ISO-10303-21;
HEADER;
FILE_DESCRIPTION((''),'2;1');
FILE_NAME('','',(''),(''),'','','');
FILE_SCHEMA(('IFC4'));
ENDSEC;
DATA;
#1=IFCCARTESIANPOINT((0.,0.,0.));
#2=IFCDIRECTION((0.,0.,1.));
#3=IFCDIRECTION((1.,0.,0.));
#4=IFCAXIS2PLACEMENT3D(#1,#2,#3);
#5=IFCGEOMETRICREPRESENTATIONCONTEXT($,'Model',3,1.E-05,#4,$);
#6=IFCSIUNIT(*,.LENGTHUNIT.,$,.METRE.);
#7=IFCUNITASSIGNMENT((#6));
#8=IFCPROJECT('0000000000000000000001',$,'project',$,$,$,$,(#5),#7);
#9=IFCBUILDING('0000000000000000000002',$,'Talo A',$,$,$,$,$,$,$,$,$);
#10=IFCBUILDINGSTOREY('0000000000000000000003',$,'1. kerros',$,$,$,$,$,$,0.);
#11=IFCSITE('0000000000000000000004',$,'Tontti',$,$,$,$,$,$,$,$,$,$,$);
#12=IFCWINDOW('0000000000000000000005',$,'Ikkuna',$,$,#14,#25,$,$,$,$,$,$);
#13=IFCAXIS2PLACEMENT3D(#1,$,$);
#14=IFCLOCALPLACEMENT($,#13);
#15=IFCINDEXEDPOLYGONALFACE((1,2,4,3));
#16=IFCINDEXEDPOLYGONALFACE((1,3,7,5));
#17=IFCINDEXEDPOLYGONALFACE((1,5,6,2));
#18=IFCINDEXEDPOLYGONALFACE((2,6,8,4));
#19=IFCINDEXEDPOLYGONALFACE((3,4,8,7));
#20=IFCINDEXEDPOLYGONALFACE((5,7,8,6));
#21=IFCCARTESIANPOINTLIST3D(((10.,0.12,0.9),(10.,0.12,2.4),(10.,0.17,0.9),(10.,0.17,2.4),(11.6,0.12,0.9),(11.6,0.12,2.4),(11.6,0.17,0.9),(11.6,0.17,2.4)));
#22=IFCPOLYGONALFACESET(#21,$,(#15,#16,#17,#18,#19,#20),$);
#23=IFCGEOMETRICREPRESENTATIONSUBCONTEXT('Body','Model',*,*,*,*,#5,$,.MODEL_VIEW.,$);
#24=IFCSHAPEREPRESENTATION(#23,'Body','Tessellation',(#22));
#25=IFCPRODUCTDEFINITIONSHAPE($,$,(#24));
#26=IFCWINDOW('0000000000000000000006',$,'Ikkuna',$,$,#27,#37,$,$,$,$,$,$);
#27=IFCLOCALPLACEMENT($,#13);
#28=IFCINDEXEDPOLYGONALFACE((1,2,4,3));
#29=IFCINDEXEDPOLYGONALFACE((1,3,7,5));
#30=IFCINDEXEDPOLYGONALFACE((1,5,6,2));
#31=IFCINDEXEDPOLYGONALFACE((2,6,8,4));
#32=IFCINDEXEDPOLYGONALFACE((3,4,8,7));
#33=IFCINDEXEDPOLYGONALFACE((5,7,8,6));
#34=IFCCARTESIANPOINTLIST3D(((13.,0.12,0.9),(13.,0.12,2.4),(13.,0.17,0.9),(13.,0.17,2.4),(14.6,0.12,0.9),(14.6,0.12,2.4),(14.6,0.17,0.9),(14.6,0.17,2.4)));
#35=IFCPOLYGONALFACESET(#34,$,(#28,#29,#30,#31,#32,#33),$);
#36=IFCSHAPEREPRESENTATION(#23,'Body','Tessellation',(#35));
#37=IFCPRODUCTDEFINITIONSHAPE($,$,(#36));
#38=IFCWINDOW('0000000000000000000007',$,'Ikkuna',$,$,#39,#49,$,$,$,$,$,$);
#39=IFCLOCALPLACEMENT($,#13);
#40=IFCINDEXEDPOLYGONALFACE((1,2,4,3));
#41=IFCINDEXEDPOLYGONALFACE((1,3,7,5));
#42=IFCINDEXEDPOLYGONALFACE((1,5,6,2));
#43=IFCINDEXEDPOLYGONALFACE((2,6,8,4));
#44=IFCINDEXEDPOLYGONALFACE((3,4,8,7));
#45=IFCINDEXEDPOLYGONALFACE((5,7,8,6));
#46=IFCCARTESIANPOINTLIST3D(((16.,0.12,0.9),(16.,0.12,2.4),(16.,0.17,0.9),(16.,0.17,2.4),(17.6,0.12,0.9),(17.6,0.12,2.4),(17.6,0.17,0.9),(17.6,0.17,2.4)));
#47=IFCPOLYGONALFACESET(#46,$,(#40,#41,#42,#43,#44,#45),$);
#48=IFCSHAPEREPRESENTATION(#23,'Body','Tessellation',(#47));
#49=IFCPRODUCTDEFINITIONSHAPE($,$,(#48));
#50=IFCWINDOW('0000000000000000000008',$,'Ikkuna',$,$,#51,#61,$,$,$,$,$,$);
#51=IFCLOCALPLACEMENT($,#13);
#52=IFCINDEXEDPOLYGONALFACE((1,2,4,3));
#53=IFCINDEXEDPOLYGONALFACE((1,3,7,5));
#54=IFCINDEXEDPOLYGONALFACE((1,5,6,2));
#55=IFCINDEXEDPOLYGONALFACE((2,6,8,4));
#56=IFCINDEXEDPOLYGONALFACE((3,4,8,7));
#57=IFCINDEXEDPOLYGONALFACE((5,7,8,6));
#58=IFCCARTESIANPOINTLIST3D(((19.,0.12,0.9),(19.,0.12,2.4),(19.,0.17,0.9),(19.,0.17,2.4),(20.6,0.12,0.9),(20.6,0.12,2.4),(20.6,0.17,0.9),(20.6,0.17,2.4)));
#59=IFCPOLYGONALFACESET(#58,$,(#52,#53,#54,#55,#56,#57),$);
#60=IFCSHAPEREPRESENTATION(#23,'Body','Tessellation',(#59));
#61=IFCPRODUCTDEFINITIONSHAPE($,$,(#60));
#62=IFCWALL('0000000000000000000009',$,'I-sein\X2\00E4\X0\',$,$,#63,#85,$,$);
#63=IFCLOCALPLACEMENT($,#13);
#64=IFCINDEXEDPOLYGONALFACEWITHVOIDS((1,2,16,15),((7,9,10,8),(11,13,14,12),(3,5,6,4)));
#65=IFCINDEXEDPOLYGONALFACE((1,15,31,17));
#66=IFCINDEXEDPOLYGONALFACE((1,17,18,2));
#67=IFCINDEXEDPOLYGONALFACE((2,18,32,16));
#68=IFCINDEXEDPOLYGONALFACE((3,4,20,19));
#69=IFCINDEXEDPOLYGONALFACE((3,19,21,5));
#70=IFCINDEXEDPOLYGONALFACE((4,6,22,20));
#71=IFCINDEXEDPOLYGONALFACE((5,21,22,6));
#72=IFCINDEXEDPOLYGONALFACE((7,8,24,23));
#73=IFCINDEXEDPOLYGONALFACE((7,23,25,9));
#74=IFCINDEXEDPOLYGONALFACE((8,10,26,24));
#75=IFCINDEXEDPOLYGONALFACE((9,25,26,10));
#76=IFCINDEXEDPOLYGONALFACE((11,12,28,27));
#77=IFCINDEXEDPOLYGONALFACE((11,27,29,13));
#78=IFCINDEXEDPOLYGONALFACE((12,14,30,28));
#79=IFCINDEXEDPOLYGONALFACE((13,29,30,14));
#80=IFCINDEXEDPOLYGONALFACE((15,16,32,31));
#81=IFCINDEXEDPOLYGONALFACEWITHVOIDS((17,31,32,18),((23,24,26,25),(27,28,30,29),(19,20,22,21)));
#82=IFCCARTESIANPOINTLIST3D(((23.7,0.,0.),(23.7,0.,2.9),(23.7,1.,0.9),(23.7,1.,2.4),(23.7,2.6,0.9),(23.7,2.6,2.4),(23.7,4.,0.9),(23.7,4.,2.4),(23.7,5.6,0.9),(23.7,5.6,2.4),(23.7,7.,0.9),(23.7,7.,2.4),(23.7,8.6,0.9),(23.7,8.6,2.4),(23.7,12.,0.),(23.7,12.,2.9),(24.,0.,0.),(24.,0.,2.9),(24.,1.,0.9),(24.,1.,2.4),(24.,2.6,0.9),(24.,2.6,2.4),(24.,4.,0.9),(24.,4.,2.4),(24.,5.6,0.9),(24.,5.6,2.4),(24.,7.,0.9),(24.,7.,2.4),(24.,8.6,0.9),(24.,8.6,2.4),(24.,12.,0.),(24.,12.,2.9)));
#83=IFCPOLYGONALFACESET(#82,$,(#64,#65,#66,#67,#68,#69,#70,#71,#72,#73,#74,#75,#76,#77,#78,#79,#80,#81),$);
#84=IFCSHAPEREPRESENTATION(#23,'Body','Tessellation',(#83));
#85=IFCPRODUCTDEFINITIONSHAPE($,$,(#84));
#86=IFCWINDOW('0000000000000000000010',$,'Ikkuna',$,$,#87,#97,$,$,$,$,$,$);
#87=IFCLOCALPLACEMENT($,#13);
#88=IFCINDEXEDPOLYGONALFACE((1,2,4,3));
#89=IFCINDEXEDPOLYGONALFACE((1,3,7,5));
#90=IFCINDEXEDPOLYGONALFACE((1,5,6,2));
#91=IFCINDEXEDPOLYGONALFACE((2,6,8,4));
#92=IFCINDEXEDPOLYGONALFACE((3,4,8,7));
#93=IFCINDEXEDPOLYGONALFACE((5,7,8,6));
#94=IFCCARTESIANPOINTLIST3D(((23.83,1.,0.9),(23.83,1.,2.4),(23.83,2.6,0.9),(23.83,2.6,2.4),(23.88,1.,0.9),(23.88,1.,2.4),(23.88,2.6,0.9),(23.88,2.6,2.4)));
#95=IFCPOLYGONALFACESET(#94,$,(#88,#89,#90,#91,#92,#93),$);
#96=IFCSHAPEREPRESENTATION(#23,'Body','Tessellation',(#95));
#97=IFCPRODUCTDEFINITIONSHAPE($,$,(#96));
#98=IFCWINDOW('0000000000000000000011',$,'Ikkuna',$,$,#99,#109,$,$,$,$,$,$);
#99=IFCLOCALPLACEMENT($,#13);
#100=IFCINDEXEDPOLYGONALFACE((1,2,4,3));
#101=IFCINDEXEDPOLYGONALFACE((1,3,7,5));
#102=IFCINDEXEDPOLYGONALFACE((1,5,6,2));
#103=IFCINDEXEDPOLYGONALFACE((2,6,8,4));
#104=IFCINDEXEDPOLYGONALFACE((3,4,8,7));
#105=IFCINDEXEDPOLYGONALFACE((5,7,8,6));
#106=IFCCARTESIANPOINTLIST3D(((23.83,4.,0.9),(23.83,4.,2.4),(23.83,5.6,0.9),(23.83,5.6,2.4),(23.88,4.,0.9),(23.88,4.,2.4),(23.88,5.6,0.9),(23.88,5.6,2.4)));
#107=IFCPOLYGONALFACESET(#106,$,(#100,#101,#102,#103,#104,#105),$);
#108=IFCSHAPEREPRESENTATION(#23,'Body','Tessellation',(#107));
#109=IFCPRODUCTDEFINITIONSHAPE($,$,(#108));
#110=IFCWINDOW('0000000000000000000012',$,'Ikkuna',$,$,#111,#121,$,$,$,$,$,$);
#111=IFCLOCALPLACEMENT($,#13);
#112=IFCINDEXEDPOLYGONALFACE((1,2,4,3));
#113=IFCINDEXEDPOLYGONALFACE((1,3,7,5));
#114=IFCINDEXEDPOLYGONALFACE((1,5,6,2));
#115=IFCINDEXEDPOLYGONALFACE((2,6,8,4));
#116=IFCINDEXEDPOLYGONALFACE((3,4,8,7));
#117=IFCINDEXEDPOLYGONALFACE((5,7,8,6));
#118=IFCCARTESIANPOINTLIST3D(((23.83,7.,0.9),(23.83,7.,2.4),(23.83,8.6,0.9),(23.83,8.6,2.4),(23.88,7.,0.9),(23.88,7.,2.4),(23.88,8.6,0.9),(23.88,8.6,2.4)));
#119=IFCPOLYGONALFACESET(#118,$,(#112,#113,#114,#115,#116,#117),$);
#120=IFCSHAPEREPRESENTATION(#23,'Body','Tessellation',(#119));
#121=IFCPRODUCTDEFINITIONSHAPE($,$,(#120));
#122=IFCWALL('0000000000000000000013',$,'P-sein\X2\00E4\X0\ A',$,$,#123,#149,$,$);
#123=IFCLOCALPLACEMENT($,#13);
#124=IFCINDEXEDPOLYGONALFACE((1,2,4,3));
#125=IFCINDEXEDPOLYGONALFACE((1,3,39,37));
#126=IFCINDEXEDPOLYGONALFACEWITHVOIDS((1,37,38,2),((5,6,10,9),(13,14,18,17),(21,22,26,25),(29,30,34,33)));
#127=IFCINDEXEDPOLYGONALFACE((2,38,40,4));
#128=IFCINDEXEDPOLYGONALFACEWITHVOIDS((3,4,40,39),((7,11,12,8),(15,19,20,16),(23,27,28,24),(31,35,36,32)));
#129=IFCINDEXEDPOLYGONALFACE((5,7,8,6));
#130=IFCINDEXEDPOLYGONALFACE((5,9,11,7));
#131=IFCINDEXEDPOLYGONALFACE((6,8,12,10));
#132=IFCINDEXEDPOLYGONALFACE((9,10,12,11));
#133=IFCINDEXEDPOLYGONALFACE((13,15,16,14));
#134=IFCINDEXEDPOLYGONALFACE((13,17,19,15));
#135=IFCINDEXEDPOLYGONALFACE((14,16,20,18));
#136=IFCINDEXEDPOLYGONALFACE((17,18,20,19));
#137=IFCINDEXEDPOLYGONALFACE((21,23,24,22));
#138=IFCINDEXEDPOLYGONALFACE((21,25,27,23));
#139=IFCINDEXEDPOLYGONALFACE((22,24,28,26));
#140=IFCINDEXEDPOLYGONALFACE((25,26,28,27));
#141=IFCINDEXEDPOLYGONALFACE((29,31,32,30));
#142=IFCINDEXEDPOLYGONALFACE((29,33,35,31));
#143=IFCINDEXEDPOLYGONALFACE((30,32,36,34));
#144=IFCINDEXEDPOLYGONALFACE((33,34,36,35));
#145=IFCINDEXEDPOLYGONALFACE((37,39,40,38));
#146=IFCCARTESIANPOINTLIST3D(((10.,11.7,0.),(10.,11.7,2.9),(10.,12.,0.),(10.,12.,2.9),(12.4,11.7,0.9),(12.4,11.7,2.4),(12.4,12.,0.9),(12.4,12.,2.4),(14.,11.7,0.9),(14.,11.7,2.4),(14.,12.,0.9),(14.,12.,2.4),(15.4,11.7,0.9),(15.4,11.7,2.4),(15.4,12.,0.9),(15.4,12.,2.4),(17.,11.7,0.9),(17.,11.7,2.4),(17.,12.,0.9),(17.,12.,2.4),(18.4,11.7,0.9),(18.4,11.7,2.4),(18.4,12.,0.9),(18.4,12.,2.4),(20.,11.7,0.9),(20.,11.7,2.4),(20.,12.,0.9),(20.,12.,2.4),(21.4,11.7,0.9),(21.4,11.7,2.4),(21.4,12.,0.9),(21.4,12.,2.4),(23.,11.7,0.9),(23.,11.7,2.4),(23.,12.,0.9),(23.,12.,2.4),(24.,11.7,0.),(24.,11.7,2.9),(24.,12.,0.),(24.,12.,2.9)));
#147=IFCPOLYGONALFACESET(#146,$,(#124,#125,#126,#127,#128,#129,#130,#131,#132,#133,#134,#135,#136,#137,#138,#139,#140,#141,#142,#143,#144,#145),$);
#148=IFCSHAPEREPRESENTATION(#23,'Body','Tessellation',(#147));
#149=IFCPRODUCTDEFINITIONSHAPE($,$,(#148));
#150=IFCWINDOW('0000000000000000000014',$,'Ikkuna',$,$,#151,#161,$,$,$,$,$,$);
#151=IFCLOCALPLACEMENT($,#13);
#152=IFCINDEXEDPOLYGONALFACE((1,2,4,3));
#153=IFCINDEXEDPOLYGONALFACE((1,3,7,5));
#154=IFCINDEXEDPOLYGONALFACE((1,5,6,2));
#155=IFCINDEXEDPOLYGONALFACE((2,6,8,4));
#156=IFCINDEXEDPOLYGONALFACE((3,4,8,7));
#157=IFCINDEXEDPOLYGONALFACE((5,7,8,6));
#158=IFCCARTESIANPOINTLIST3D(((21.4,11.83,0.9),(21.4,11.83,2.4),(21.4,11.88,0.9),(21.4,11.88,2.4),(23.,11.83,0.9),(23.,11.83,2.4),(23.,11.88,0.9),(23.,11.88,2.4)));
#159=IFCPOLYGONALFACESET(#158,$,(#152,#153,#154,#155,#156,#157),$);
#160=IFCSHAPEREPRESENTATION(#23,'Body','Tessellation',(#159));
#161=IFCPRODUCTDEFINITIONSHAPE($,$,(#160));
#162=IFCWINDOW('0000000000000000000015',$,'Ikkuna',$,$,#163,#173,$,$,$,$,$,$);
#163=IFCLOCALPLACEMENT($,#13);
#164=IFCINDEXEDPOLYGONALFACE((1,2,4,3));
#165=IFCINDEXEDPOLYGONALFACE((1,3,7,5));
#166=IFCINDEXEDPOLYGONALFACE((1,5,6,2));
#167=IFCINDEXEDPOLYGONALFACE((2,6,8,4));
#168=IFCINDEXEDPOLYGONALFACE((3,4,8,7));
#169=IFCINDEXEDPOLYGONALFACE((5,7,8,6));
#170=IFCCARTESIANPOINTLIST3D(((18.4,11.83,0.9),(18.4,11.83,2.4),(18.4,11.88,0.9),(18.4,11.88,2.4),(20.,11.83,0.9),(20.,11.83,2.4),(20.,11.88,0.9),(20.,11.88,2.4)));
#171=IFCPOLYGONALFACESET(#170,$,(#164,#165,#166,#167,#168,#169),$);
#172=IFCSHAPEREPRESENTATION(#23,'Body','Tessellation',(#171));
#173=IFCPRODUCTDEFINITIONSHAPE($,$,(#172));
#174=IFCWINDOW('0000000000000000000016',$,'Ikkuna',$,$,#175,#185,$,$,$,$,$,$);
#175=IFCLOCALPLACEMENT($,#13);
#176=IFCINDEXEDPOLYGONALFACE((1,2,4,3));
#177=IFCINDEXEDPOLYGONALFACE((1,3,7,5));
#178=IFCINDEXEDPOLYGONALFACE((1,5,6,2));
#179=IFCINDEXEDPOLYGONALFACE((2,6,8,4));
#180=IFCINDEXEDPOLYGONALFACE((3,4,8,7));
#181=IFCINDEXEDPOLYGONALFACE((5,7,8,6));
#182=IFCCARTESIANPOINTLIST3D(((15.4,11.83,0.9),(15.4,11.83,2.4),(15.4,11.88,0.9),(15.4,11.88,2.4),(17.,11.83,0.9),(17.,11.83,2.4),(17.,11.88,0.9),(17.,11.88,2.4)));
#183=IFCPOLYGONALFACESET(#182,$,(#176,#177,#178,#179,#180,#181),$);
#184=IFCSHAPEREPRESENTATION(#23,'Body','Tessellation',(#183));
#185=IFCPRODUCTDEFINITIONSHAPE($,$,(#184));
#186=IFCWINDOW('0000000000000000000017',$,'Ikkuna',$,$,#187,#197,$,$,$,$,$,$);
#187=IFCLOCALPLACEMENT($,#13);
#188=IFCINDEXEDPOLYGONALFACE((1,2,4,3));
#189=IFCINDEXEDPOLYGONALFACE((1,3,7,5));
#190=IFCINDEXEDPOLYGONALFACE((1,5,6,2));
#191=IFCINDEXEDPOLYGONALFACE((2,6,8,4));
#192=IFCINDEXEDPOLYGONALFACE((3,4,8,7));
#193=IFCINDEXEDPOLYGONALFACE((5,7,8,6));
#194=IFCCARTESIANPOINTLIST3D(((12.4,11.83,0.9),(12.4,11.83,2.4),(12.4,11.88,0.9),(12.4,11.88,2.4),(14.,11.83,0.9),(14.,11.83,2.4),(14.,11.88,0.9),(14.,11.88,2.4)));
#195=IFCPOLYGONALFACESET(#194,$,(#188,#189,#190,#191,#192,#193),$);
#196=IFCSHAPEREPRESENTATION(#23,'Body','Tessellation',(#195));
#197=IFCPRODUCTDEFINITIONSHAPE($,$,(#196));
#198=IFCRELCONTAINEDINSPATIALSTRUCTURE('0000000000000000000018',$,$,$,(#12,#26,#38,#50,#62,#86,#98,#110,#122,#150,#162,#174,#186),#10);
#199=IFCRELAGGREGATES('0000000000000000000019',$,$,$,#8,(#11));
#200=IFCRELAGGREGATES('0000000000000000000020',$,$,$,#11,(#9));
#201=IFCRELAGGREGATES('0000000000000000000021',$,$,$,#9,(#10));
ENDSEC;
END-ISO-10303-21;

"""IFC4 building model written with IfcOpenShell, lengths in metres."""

from ifc_helpers import new_model, si_unit, frame, origin_with_axes, place, context, subcontext, project, spatial, indexed_curve, outline, extrude, element, save


model = new_model("IFC4")

# Units and contexts
model_context = context("Model", 3, precision=1e-05, world=origin_with_axes())
body_context = subcontext(model_context, "Body", "Model", "MODEL_VIEW")
ifc_project = project(units=[si_unit("LENGTHUNIT", "METRE")], contexts=[model_context])

# Site, building, storey
site = spatial("IfcSite", under=ifc_project, Name="Tontti")
building = spatial("IfcBuilding", under=site, Name="Talo A")
storey = spatial("IfcBuildingStorey", under=building, Name="1. kerros", Elevation=0.0)

# Windows
for number, where, z_axis, x_axis, name in (
    (1, (10.0, 0.12, 0.9), (0.0, 0.0, 1.0), (1.0, 0.0, 0.0), "Ikkuna"),
    (2, (13.0, 0.12, 0.9), (0.0, 0.0, 1.0), (1.0, 0.0, 0.0), "Ikkuna"),
    (3, (16.0, 0.12, 0.9), (0.0, 0.0, 1.0), (1.0, 0.0, 0.0), "Ikkuna"),
    (4, (19.0, 0.12, 0.9), (0.0, 0.0, 1.0), (1.0, 0.0, 0.0), "Ikkuna"),
):
    element("IfcWindow", number, at=place(None, frame(where, z_axis=z_axis, x_axis=x_axis)), inside=storey, Name=name, context=body_context, shape_type="SweptSolid", body=[
        extrude(outline(indexed_curve([(0.0, 0.0), (0.0, 0.05), (1.6, 0.05), (1.6, 0.0), (0.0, 0.0)], self_intersect=False)), origin_with_axes(), (0.0, 0.0, 1.0), 1.5),
    ])

# Wall, openings
wall_1_placement = place(None, frame((24.0, 0.0, 0.0), z_axis=(0.0, 0.0, 1.0), x_axis=(0.0, 1.0, 0.0)))
wall_1 = element("IfcWall", 5, at=wall_1_placement, inside=storey, Name="I-seinä", context=body_context, shape_type="SweptSolid", body=[
    extrude(outline(indexed_curve([(0.0, 0.0), (0.0, 0.3), (12.0, 0.3), (12.0, 0.0), (0.0, 0.0)], self_intersect=False)), origin_with_axes(), (0.0, 0.0, 1.0), 2.9),
])
opening_1_placement = place(wall_1_placement, frame((1.0, -0.1, 0.9), z_axis=(0.0, 0.0, 1.0), x_axis=(1.0, 0.0, 0.0)))
element("IfcOpeningElement", 6, at=opening_1_placement, cuts=wall_1, context=body_context, shape_type="SweptSolid", body=[
    extrude(outline(indexed_curve([(0.0, 0.0), (0.0, 0.5), (1.6, 0.5), (1.6, 0.0), (0.0, 0.0)], self_intersect=False)), origin_with_axes(), (0.0, 0.0, 1.0), 1.5),
])
opening_2_placement = place(wall_1_placement, frame((4.0, -0.1, 0.9), z_axis=(0.0, 0.0, 1.0), x_axis=(1.0, 0.0, 0.0)))
element("IfcOpeningElement", 7, at=opening_2_placement, cuts=wall_1, context=body_context, shape_type="SweptSolid", body=[
    extrude(outline(indexed_curve([(0.0, 0.0), (0.0, 0.5), (1.6, 0.5), (1.6, 0.0), (0.0, 0.0)], self_intersect=False)), origin_with_axes(), (0.0, 0.0, 1.0), 1.5),
])
opening_3_placement = place(wall_1_placement, frame((7.0, -0.1, 0.9), z_axis=(0.0, 0.0, 1.0), x_axis=(1.0, 0.0, 0.0)))
element("IfcOpeningElement", 8, at=opening_3_placement, cuts=wall_1, context=body_context, shape_type="SweptSolid", body=[
    extrude(outline(indexed_curve([(0.0, 0.0), (0.0, 0.5), (1.6, 0.5), (1.6, 0.0), (0.0, 0.0)], self_intersect=False)), origin_with_axes(), (0.0, 0.0, 1.0), 1.5),
])

# Windows
for number, where, z_axis, x_axis, name in (
    (9, (23.88, 1.0, 0.9), (0.0, 0.0, 1.0), (0.0, 1.0, 0.0), "Ikkuna"),
    (10, (23.88, 4.0, 0.9), (0.0, 0.0, 1.0), (0.0, 1.0, 0.0), "Ikkuna"),
    (11, (23.88, 7.0, 0.9), (0.0, 0.0, 1.0), (0.0, 1.0, 0.0), "Ikkuna"),
):
    element("IfcWindow", number, at=place(None, frame(where, z_axis=z_axis, x_axis=x_axis)), inside=storey, Name=name, context=body_context, shape_type="SweptSolid", body=[
        extrude(outline(indexed_curve([(0.0, 0.0), (0.0, 0.05), (1.6, 0.05), (1.6, 0.0), (0.0, 0.0)], self_intersect=False)), origin_with_axes(), (0.0, 0.0, 1.0), 1.5),
    ])

# Wall, openings
wall_2_placement = place(None, frame((24.0, 12.0, 0.0), z_axis=(0.0, 0.0, 1.0), x_axis=(-1.0, 0.0, 0.0)))
wall_2 = element("IfcWall", 12, at=wall_2_placement, inside=storey, Name="P-seinä A", context=body_context, shape_type="SweptSolid", body=[
    extrude(outline(indexed_curve([(0.0, 0.0), (0.0, 0.3), (14.0, 0.3), (14.0, 0.0), (0.0, 0.0)], self_intersect=False)), origin_with_axes(), (0.0, 0.0, 1.0), 2.9),
])
opening_4_placement = place(wall_2_placement, frame((1.0, -0.1, 0.9), z_axis=(0.0, 0.0, 1.0), x_axis=(1.0, 0.0, 0.0)))
element("IfcOpeningElement", 13, at=opening_4_placement, cuts=wall_2, context=body_context, shape_type="SweptSolid", body=[
    extrude(outline(indexed_curve([(0.0, 0.0), (0.0, 0.5), (1.6, 0.5), (1.6, 0.0), (0.0, 0.0)], self_intersect=False)), origin_with_axes(), (0.0, 0.0, 1.0), 1.5),
])
opening_5_placement = place(wall_2_placement, frame((4.0, -0.1, 0.9), z_axis=(0.0, 0.0, 1.0), x_axis=(1.0, 0.0, 0.0)))
element("IfcOpeningElement", 14, at=opening_5_placement, cuts=wall_2, context=body_context, shape_type="SweptSolid", body=[
    extrude(outline(indexed_curve([(0.0, 0.0), (0.0, 0.5), (1.6, 0.5), (1.6, 0.0), (0.0, 0.0)], self_intersect=False)), origin_with_axes(), (0.0, 0.0, 1.0), 1.5),
])
opening_6_placement = place(wall_2_placement, frame((7.0, -0.1, 0.9), z_axis=(0.0, 0.0, 1.0), x_axis=(1.0, 0.0, 0.0)))
element("IfcOpeningElement", 15, at=opening_6_placement, cuts=wall_2, context=body_context, shape_type="SweptSolid", body=[
    extrude(outline(indexed_curve([(0.0, 0.0), (0.0, 0.5), (1.6, 0.5), (1.6, 0.0), (0.0, 0.0)], self_intersect=False)), origin_with_axes(), (0.0, 0.0, 1.0), 1.5),
])
opening_7_placement = place(wall_2_placement, frame((10.0, -0.1, 0.9), z_axis=(0.0, 0.0, 1.0), x_axis=(1.0, 0.0, 0.0)))
element("IfcOpeningElement", 16, at=opening_7_placement, cuts=wall_2, context=body_context, shape_type="SweptSolid", body=[
    extrude(outline(indexed_curve([(0.0, 0.0), (0.0, 0.5), (1.6, 0.5), (1.6, 0.0), (0.0, 0.0)], self_intersect=False)), origin_with_axes(), (0.0, 0.0, 1.0), 1.5),
])

# Windows
for number, where, z_axis, x_axis, name in (
    (17, (23.0, 11.88, 0.9), (0.0, 0.0, 1.0), (-1.0, 0.0, 0.0), "Ikkuna"),
    (18, (20.0, 11.88, 0.9), (0.0, 0.0, 1.0), (-1.0, 0.0, 0.0), "Ikkuna"),
    (19, (17.0, 11.88, 0.9), (0.0, 0.0, 1.0), (-1.0, 0.0, 0.0), "Ikkuna"),
    (20, (14.0, 11.88, 0.9), (0.0, 0.0, 1.0), (-1.0, 0.0, 0.0), "Ikkuna"),
):
    element("IfcWindow", number, at=place(None, frame(where, z_axis=z_axis, x_axis=x_axis)), inside=storey, Name=name, context=body_context, shape_type="SweptSolid", body=[
        extrude(outline(indexed_curve([(0.0, 0.0), (0.0, 0.05), (1.6, 0.05), (1.6, 0.0), (0.0, 0.0)], self_intersect=False)), origin_with_axes(), (0.0, 0.0, 1.0), 1.5),
    ])

save(model, "model.ifc")
